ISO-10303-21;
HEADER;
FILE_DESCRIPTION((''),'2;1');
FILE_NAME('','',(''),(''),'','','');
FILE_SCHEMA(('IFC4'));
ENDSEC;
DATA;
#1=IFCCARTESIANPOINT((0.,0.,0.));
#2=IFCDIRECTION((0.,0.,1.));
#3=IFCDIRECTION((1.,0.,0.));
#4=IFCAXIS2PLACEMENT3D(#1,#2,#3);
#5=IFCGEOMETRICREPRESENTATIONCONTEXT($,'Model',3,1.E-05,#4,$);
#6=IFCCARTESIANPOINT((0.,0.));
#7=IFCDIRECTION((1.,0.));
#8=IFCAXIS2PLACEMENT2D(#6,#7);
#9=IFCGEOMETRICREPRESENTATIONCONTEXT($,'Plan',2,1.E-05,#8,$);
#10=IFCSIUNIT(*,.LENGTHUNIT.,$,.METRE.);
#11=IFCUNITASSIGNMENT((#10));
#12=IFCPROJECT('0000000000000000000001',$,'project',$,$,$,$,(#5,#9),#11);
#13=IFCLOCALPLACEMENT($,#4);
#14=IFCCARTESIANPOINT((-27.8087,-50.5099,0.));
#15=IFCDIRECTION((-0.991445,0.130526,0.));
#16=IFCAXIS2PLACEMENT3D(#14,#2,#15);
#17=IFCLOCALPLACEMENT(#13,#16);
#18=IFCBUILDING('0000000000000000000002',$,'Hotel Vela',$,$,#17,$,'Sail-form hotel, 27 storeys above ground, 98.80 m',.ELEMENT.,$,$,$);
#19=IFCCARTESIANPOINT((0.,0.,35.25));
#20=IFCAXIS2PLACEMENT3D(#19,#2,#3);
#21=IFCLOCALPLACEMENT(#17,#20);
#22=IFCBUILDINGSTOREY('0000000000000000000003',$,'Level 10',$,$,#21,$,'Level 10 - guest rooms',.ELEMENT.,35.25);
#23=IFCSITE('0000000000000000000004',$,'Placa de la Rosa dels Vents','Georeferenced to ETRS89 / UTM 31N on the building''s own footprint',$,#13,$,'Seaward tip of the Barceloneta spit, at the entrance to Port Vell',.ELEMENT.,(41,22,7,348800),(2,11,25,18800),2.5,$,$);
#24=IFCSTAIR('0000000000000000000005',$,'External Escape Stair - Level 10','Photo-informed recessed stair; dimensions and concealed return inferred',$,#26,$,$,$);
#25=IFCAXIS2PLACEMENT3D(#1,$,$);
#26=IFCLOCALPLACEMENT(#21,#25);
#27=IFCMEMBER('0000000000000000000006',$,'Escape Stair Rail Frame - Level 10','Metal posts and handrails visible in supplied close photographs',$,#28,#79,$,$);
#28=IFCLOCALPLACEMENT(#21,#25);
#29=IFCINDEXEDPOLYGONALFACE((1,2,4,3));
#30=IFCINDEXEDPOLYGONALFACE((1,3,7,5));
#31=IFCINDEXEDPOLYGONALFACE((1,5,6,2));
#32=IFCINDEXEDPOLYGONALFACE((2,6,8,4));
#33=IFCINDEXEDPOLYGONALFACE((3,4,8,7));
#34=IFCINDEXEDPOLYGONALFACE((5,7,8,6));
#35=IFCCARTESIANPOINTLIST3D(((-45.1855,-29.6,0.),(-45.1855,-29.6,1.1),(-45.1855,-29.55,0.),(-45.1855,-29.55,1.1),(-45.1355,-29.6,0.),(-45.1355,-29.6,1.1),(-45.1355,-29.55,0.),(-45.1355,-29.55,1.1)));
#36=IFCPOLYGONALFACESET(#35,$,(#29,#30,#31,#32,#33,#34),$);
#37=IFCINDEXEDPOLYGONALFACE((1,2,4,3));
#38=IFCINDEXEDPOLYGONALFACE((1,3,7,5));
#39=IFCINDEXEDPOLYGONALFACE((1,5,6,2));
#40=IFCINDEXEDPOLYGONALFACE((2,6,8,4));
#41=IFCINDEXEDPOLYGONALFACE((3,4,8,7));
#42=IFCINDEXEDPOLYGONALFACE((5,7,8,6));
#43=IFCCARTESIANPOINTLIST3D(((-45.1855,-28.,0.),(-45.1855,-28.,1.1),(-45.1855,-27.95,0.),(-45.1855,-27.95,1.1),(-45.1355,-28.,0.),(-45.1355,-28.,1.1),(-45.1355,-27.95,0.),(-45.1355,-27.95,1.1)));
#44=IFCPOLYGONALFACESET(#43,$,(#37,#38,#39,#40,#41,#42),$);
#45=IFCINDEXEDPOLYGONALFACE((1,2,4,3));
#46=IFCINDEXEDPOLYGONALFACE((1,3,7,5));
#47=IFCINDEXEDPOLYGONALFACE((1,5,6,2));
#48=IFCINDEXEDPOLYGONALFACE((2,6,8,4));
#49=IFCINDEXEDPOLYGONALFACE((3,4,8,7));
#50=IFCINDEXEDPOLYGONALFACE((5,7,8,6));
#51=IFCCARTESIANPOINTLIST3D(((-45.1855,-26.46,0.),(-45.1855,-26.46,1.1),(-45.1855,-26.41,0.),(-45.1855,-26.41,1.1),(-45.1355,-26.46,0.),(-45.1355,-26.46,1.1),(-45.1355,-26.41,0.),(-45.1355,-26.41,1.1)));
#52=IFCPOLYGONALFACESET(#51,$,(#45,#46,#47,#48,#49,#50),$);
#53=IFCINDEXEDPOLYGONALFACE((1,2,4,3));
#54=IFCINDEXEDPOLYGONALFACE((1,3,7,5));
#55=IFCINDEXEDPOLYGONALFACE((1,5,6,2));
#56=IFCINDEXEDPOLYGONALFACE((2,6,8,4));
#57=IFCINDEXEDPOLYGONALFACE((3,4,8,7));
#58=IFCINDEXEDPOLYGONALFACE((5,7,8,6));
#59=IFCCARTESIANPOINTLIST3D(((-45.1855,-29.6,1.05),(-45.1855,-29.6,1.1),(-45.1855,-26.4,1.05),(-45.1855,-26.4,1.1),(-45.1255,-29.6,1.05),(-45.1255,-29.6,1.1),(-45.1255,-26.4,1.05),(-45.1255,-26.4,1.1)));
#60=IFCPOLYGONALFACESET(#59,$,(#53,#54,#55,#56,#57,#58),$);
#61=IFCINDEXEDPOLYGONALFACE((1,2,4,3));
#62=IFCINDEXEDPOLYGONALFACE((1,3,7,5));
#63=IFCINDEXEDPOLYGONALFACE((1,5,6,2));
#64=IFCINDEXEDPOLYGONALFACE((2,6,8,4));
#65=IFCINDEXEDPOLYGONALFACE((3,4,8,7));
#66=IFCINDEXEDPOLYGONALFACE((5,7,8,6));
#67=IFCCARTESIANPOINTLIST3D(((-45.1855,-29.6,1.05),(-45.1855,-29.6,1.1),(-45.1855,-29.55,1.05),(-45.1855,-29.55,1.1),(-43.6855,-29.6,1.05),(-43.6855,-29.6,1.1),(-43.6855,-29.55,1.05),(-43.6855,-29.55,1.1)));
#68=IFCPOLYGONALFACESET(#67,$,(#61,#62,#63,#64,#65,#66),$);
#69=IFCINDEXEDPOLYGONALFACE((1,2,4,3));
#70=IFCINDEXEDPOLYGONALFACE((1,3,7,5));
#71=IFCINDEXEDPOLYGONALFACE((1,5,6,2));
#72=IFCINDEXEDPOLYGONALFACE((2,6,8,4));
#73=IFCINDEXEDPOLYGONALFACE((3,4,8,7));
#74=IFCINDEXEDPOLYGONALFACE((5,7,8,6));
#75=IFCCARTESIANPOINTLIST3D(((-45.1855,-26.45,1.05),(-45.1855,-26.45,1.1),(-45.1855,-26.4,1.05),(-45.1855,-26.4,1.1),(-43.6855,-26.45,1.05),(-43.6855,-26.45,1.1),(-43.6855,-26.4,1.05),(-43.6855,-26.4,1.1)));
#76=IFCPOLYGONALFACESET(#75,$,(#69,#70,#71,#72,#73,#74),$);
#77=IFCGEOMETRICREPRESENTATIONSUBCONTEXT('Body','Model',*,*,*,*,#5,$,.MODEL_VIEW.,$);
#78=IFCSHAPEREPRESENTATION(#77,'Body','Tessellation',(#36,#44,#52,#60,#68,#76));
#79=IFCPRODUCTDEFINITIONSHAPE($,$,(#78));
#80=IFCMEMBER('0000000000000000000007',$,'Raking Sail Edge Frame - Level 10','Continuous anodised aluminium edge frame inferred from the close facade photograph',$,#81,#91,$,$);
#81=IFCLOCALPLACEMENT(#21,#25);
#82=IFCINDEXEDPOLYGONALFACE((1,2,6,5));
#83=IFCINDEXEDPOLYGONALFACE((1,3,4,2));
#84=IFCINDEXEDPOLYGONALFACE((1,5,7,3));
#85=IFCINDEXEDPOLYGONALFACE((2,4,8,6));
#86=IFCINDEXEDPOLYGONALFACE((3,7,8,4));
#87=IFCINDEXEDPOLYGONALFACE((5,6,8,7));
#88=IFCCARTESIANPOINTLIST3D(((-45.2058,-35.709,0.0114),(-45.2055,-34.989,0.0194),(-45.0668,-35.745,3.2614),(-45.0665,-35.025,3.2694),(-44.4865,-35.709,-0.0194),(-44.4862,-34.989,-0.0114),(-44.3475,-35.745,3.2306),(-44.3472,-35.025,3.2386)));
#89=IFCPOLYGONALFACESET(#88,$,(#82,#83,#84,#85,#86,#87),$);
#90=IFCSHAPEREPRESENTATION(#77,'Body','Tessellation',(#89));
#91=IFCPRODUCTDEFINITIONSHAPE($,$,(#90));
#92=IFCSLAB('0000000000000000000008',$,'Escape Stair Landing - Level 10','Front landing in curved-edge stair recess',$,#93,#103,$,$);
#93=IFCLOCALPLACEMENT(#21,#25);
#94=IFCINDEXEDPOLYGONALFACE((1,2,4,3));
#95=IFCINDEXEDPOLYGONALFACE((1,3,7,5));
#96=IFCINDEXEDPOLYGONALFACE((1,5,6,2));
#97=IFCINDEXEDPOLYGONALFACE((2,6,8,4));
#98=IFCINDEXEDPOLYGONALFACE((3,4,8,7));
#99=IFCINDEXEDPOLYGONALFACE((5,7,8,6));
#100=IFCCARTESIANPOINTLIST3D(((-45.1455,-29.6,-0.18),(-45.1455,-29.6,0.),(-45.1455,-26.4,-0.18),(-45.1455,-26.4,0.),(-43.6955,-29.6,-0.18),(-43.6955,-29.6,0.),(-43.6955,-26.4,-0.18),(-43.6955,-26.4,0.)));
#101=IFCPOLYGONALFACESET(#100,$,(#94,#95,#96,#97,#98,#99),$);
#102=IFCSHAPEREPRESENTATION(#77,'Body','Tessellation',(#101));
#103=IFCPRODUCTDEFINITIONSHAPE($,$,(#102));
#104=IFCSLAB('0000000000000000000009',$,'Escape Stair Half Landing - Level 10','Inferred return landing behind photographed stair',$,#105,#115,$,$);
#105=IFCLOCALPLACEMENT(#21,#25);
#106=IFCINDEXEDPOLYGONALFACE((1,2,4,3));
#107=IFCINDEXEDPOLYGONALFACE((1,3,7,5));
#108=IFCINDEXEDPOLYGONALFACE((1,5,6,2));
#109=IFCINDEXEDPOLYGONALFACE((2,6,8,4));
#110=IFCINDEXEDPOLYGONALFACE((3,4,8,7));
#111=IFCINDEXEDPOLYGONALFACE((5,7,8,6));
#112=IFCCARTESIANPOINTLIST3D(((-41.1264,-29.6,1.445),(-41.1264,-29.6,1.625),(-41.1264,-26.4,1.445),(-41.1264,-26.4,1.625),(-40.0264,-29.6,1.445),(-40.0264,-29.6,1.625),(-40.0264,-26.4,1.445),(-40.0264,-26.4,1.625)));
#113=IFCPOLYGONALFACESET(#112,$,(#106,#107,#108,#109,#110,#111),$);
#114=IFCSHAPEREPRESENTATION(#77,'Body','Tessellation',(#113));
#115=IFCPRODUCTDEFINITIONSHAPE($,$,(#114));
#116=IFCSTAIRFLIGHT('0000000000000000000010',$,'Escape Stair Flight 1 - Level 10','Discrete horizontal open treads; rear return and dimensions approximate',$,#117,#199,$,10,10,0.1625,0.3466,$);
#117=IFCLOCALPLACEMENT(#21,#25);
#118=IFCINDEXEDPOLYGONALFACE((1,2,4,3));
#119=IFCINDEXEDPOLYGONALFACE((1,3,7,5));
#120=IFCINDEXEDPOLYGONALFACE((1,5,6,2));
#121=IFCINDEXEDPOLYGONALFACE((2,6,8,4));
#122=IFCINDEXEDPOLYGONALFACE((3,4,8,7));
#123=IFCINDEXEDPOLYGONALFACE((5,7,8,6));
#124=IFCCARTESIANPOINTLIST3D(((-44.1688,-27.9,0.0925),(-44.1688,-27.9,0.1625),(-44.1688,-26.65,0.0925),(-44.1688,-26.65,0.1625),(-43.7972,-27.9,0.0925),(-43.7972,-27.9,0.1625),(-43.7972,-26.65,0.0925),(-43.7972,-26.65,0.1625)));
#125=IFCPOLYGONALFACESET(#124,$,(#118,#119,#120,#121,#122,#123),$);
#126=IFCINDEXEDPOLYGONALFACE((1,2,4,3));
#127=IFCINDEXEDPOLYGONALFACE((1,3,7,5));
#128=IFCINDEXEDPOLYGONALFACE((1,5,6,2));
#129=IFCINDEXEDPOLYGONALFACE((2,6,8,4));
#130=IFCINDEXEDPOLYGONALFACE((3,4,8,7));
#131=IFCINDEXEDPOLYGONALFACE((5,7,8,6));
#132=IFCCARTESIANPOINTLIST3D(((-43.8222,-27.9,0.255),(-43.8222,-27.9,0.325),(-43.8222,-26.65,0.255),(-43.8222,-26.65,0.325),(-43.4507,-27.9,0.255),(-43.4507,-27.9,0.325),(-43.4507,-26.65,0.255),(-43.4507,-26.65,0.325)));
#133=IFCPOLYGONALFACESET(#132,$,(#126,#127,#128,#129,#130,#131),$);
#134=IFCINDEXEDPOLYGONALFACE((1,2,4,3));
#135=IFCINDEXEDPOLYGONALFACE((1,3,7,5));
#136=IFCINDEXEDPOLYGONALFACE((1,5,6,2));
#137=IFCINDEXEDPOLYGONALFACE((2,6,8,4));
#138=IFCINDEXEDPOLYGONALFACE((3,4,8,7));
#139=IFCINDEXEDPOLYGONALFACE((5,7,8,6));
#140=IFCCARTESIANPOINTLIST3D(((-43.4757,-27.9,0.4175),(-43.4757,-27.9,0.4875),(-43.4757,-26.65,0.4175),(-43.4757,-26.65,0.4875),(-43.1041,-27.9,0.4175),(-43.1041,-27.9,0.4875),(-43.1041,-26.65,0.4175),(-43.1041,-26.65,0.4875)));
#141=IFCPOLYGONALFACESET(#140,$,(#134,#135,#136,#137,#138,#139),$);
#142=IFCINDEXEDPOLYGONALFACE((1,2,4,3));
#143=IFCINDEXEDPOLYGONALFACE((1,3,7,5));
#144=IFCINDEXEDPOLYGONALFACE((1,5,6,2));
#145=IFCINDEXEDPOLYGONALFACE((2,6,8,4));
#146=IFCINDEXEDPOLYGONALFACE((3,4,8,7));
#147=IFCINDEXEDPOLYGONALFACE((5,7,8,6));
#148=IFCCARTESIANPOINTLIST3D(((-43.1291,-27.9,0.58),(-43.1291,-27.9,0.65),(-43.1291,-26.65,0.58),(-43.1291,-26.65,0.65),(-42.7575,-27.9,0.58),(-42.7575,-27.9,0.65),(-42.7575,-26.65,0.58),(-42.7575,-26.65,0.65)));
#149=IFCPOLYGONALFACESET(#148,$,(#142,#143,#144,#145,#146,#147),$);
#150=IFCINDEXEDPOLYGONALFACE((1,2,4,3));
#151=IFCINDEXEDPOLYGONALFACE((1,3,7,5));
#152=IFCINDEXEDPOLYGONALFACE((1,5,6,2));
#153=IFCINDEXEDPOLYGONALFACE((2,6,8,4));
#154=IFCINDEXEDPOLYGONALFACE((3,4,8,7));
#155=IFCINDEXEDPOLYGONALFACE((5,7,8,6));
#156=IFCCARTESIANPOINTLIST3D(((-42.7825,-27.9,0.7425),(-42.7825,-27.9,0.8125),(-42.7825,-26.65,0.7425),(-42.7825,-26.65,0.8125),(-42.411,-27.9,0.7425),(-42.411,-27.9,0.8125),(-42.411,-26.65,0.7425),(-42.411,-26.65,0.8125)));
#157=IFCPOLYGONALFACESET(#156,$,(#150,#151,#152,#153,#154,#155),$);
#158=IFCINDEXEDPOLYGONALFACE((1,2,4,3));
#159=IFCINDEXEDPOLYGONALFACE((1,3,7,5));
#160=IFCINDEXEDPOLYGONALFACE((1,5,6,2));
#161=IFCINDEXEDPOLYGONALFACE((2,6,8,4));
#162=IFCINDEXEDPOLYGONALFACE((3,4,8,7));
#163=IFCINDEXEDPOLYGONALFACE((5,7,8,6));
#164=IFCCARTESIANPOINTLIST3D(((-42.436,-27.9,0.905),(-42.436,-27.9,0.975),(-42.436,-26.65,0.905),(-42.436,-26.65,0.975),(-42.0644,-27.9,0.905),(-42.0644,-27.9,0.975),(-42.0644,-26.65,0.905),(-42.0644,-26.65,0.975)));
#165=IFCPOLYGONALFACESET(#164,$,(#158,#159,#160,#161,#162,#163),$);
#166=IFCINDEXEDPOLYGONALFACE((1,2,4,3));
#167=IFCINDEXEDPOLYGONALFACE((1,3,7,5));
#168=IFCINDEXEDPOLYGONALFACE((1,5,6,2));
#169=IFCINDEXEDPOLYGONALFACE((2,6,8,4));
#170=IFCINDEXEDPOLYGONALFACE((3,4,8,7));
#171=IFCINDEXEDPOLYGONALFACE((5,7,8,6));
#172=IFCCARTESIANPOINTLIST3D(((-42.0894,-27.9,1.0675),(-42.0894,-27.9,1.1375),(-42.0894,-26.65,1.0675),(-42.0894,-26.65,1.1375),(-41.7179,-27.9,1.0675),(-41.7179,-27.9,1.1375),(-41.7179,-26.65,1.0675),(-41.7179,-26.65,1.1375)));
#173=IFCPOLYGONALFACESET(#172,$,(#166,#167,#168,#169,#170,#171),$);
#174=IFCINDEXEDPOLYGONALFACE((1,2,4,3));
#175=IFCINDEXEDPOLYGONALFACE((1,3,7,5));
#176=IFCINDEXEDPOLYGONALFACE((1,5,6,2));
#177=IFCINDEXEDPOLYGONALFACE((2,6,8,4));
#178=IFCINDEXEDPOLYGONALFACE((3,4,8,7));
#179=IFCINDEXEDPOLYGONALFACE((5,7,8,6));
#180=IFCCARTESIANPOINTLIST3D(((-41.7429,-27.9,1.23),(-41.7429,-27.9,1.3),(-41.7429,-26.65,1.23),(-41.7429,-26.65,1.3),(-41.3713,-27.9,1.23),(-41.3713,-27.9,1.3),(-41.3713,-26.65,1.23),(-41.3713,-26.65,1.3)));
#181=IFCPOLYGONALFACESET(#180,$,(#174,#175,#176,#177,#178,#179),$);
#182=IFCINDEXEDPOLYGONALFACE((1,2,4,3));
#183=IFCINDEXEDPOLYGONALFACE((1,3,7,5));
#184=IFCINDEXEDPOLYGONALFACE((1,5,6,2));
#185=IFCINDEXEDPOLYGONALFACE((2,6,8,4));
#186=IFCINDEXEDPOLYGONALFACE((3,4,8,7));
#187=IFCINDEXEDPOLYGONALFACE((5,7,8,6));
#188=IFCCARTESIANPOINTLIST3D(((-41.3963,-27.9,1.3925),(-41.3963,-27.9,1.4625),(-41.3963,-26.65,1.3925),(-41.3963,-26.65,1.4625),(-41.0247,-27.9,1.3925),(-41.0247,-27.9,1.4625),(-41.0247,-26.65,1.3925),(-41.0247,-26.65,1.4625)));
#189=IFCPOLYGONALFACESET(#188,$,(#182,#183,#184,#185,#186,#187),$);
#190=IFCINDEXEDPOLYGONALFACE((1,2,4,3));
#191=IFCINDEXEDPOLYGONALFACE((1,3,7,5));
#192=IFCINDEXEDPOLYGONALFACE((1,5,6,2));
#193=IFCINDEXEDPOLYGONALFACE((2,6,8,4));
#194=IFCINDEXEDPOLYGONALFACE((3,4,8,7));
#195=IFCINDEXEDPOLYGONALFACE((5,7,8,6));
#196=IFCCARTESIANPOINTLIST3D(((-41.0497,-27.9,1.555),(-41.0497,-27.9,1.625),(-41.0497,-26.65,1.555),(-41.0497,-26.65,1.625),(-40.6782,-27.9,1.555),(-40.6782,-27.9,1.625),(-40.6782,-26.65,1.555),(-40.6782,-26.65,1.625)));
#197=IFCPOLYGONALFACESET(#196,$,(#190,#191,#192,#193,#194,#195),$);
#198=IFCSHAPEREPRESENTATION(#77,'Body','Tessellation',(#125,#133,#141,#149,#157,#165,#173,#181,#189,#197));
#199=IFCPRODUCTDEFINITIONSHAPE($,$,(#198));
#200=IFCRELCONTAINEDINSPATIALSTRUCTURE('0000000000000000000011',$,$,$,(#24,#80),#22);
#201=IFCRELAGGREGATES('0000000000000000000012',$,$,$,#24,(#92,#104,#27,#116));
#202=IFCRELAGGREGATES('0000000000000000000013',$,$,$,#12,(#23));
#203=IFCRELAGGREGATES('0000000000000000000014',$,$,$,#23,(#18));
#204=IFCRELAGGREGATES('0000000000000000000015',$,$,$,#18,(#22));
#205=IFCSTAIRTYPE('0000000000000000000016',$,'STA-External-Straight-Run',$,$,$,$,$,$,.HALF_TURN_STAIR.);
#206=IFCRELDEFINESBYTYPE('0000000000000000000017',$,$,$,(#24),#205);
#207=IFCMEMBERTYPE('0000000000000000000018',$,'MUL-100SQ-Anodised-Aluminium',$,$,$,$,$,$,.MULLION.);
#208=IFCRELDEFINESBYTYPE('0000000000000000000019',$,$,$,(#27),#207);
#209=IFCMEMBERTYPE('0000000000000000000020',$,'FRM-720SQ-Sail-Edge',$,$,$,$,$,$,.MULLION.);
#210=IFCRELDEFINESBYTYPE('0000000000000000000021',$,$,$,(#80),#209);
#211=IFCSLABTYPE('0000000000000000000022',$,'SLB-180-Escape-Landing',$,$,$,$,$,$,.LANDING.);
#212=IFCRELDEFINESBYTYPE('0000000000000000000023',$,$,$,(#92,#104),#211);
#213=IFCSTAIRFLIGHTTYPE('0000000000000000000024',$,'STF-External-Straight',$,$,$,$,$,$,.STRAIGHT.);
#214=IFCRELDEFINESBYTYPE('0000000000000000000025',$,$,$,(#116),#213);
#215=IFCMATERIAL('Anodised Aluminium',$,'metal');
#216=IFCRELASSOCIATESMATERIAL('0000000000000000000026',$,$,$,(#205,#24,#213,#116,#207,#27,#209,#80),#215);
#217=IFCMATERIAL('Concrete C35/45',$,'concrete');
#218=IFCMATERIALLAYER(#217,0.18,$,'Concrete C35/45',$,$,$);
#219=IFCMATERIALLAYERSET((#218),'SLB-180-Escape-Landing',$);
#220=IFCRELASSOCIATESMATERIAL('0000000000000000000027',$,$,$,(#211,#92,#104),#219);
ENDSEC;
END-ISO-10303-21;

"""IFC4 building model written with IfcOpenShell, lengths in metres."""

from ifc_helpers import new_model, si_unit, frame, origin_with_axes, origin_2d_with_axis, place, context, subcontext, project, spatial, line, indexed_curve, rectangle, outline, extrude, material, layer, layer_set, layer_usage, material_profile, profile_set, profile_usage, type_object, element, aggregate, save


model = new_model("IFC4")

# Units and contexts
model_context = context("Model", 3, precision=1e-05, world=origin_with_axes())
plan_context = context("Plan", 2, precision=1e-05, world=origin_2d_with_axis())
body_context = subcontext(model_context, "Body", "Model", "MODEL_VIEW")
ifc_project = project(units=[si_unit("LENGTHUNIT", "METRE")], contexts=[model_context, plan_context])

# Site, building, storey
site_placement = place(None, origin_with_axes())
site = spatial("IfcSite", under=ifc_project, at=site_placement, Name="Placa de la Rosa dels Vents", Description="Georeferenced to ETRS89 / UTM 31N on the building's own footprint", LongName="Seaward tip of the Barceloneta spit, at the entrance to Port Vell", CompositionType="ELEMENT", RefLatitude=(41, 22, 7, 348800), RefLongitude=(2, 11, 25, 18800), RefElevation=2.5)
building_placement = place(site_placement, frame((-27.8087, -50.5099, 0.0), z_axis=(0.0, 0.0, 1.0), x_axis=(-0.991445, 0.130526, 0.0)))
building = spatial("IfcBuilding", under=site, at=building_placement, Name="Hotel Vela", LongName="Sail-form hotel, 27 storeys above ground, 98.80 m", CompositionType="ELEMENT")
storey_placement = place(building_placement, frame((0.0, 0.0, 35.25), z_axis=(0.0, 0.0, 1.0), x_axis=(1.0, 0.0, 0.0)))
storey = spatial("IfcBuildingStorey", under=building, at=storey_placement, Name="Level 10", LongName="Level 10 - guest rooms", CompositionType="ELEMENT", Elevation=35.25)

# Stair, member
ifc_material_1 = material(Name="Anodised Aluminium", Category="metal")
stair_type = type_object("IfcStairType", Name="STA-External-Straight-Run", PredefinedType="HALF_TURN_STAIR", material=ifc_material_1)
stair_placement = place(storey_placement, frame((0.0, 0.0, -35.25), z_axis=(0.0, 0.0, 1.0), x_axis=(1.0, 0.0, 0.0)))
stair = element("IfcStair", 1, at=stair_placement, inside=storey, type_object=stair_type, material=ifc_material_1, Name="External Escape Stair - Level 10", Description="Photo-informed recessed stair; dimensions and concealed return inferred")
ifc_material_profile_1 = material_profile(ifc_material_1, rectangle(XDim=0.1, YDim=0.1))
ifc_profile_set_1 = profile_set([ifc_material_profile_1], Name="MUL-100SQ-Anodised-Aluminium")
ifc_profile_usage_1 = profile_usage(ifc_profile_set_1)
member_type_1 = type_object("IfcMemberType", Name="MUL-100SQ-Anodised-Aluminium", PredefinedType="MULLION", material=ifc_profile_set_1)
member_1_placement = place(stair_placement, origin_with_axes())
member_1 = element("IfcMember", 2, at=member_1_placement, type_object=member_type_1, material=ifc_profile_usage_1, Name="Escape Stair Rail Frame - Level 10", Description="Metal posts and handrails visible in supplied close photographs", context=body_context, shape_type="SweptSolid", body=[
    extrude(outline(indexed_curve([(0.0, 0.0), (0.05, 0.0), (0.05, 0.05), (0.0, 0.05)], segments=[line(1, 2, 3, 4, 1)])), frame((-45.1855, -29.6, 35.25), z_axis=(0.0, 0.0, 1.0), x_axis=(1.0, 0.0, 0.0)), (0.0, 0.0, 1.0), 1.1),
    extrude(outline(indexed_curve([(0.0, 0.0), (0.05, 0.0), (0.05, 0.05), (0.0, 0.05)], segments=[line(1, 2, 3, 4, 1)])), frame((-45.1855, -28.0, 35.25), z_axis=(0.0, 0.0, 1.0), x_axis=(1.0, 0.0, 0.0)), (0.0, 0.0, 1.0), 1.1),
    extrude(outline(indexed_curve([(0.0, 0.0), (0.05, 0.0), (0.05, 0.05), (0.0, 0.05)], segments=[line(1, 2, 3, 4, 1)])), frame((-45.1855, -26.46, 35.25), z_axis=(0.0, 0.0, 1.0), x_axis=(1.0, 0.0, 0.0)), (0.0, 0.0, 1.0), 1.1),
    extrude(outline(indexed_curve([(0.0, 0.0), (0.06, 0.0), (0.06, 3.2), (0.0, 3.2)], segments=[line(1, 2, 3, 4, 1)])), frame((-45.1855, -29.6, 36.3), z_axis=(0.0, 0.0, 1.0), x_axis=(1.0, 0.0, 0.0)), (0.0, 0.0, 1.0), 0.05),
    extrude(outline(indexed_curve([(0.0, 0.0), (1.5, 0.0), (1.5, 0.05), (0.0, 0.05)], segments=[line(1, 2, 3, 4, 1)])), frame((-45.1855, -29.6, 36.3), z_axis=(0.0, 0.0, 1.0), x_axis=(1.0, 0.0, 0.0)), (0.0, 0.0, 1.0), 0.05),
    extrude(outline(indexed_curve([(0.0, 0.0), (1.5, 0.0), (1.5, 0.05), (0.0, 0.05)], segments=[line(1, 2, 3, 4, 1)])), frame((-45.1855, -26.45, 36.3), z_axis=(0.0, 0.0, 1.0), x_axis=(1.0, 0.0, 0.0)), (0.0, 0.0, 1.0), 0.05),
])

# Member
ifc_material_profile_2 = material_profile(ifc_material_1, rectangle(XDim=0.72, YDim=0.72))
ifc_profile_set_2 = profile_set([ifc_material_profile_2], Name="FRM-720SQ-Sail-Edge")
ifc_profile_usage_2 = profile_usage(ifc_profile_set_2)
member_type_2 = type_object("IfcMemberType", Name="FRM-720SQ-Sail-Edge", PredefinedType="MULLION", material=ifc_profile_set_2)
member_2_placement = place(storey_placement, frame((-44.846, -35.349, 0.0), z_axis=(0.042728, -0.011066, 0.999025), x_axis=(0.999087, 0.0, -0.04273)))
element("IfcMember", 3, at=member_2_placement, inside=storey, type_object=member_type_2, material=ifc_profile_usage_2, Name="Raking Sail Edge Frame - Level 10", Description="Continuous anodised aluminium edge frame inferred from the close facade photograph", context=body_context, shape_type="SweptSolid", body=[
    extrude(outline(indexed_curve([(-0.36, -0.36), (0.36, -0.36), (0.36, 0.36), (-0.36, 0.36)], segments=[line(1, 2, 3, 4, 1)])), origin_with_axes(), (0.0, 0.0, 1.0), 3.2532),
])

# Slabs
ifc_material_2 = material(Name="Concrete C35/45", Category="concrete")
ifc_layer = layer(ifc_material_2, 0.18, Name="Concrete C35/45")
ifc_layer_set = layer_set([ifc_layer], Name="SLB-180-Escape-Landing")
ifc_layer_usage_1 = layer_usage(ifc_layer_set, "AXIS3", "POSITIVE", 0.0)
slab_type = type_object("IfcSlabType", Name="SLB-180-Escape-Landing", PredefinedType="LANDING", material=ifc_layer_set)
slab_1_placement = place(stair_placement, frame((-45.1455, -29.6, 35.07), z_axis=(0.0, 0.0, 1.0), x_axis=(1.0, 0.0, 0.0)))
slab_1 = element("IfcSlab", 4, at=slab_1_placement, type_object=slab_type, material=ifc_layer_usage_1, Name="Escape Stair Landing - Level 10", Description="Front landing in curved-edge stair recess", context=body_context, shape_type="SweptSolid", body=[
    extrude(outline(indexed_curve([(0.0, 0.0), (1.45, 0.0), (1.45, 3.2), (0.0, 3.2)], segments=[line(1, 2, 3, 4, 1)])), origin_with_axes(), (0.0, 0.0, 1.0), 0.18),
])
ifc_layer_usage_2 = layer_usage(ifc_layer_set, "AXIS3", "POSITIVE", 0.0)
slab_2_placement = place(stair_placement, frame((-41.1264, -29.6, 36.695), z_axis=(0.0, 0.0, 1.0), x_axis=(1.0, 0.0, 0.0)))
slab_2 = element("IfcSlab", 5, at=slab_2_placement, type_object=slab_type, material=ifc_layer_usage_2, Name="Escape Stair Half Landing - Level 10", Description="Inferred return landing behind photographed stair", context=body_context, shape_type="SweptSolid", body=[
    extrude(outline(indexed_curve([(0.0, 0.0), (1.1, 0.0), (1.1, 3.2), (0.0, 3.2)], segments=[line(1, 2, 3, 4, 1)])), origin_with_axes(), (0.0, 0.0, 1.0), 0.18),
])

# Stair flight
stair_flight_type = type_object("IfcStairFlightType", Name="STF-External-Straight", PredefinedType="STRAIGHT", material=ifc_material_1)
stair_flight_1_placement = place(stair_placement, origin_with_axes())
stair_flight_1 = element("IfcStairFlight", 6, at=stair_flight_1_placement, type_object=stair_flight_type, material=ifc_material_1, Name="Escape Stair Flight 1 - Level 10", Description="Discrete horizontal open treads; rear return and dimensions approximate", NumberOfRisers=10, NumberOfTreads=10, RiserHeight=0.1625, TreadLength=0.3466, context=body_context, shape_type="SweptSolid", body=[
    extrude(outline(indexed_curve([(0.0, 0.0), (0.3716, 0.0), (0.3716, 1.25), (0.0, 1.25)], segments=[line(1, 2, 3, 4, 1)])), frame((-44.1688, -27.9, 35.3425), z_axis=(0.0, 0.0, 1.0), x_axis=(1.0, 0.0, 0.0)), (0.0, 0.0, 1.0), 0.07),
    extrude(outline(indexed_curve([(0.0, 0.0), (0.3716, 0.0), (0.3716, 1.25), (0.0, 1.25)], segments=[line(1, 2, 3, 4, 1)])), frame((-43.8222, -27.9, 35.505), z_axis=(0.0, 0.0, 1.0), x_axis=(1.0, 0.0, 0.0)), (0.0, 0.0, 1.0), 0.07),
    extrude(outline(indexed_curve([(0.0, 0.0), (0.3716, 0.0), (0.3716, 1.25), (0.0, 1.25)], segments=[line(1, 2, 3, 4, 1)])), frame((-43.4757, -27.9, 35.6675), z_axis=(0.0, 0.0, 1.0), x_axis=(1.0, 0.0, 0.0)), (0.0, 0.0, 1.0), 0.07),
    extrude(outline(indexed_curve([(0.0, 0.0), (0.3716, 0.0), (0.3716, 1.25), (0.0, 1.25)], segments=[line(1, 2, 3, 4, 1)])), frame((-43.1291, -27.9, 35.83), z_axis=(0.0, 0.0, 1.0), x_axis=(1.0, 0.0, 0.0)), (0.0, 0.0, 1.0), 0.07),
    extrude(outline(indexed_curve([(0.0, 0.0), (0.3716, 0.0), (0.3716, 1.25), (0.0, 1.25)], segments=[line(1, 2, 3, 4, 1)])), frame((-42.7825, -27.9, 35.9925), z_axis=(0.0, 0.0, 1.0), x_axis=(1.0, 0.0, 0.0)), (0.0, 0.0, 1.0), 0.07),
    extrude(outline(indexed_curve([(0.0, 0.0), (0.3716, 0.0), (0.3716, 1.25), (0.0, 1.25)], segments=[line(1, 2, 3, 4, 1)])), frame((-42.436, -27.9, 36.155), z_axis=(0.0, 0.0, 1.0), x_axis=(1.0, 0.0, 0.0)), (0.0, 0.0, 1.0), 0.07),
    extrude(outline(indexed_curve([(0.0, 0.0), (0.3716, 0.0), (0.3716, 1.25), (0.0, 1.25)], segments=[line(1, 2, 3, 4, 1)])), frame((-42.0894, -27.9, 36.3175), z_axis=(0.0, 0.0, 1.0), x_axis=(1.0, 0.0, 0.0)), (0.0, 0.0, 1.0), 0.07),
    extrude(outline(indexed_curve([(0.0, 0.0), (0.3716, 0.0), (0.3716, 1.25), (0.0, 1.25)], segments=[line(1, 2, 3, 4, 1)])), frame((-41.7429, -27.9, 36.48), z_axis=(0.0, 0.0, 1.0), x_axis=(1.0, 0.0, 0.0)), (0.0, 0.0, 1.0), 0.07),
    extrude(outline(indexed_curve([(0.0, 0.0), (0.3716, 0.0), (0.3716, 1.25), (0.0, 1.25)], segments=[line(1, 2, 3, 4, 1)])), frame((-41.3963, -27.9, 36.6425), z_axis=(0.0, 0.0, 1.0), x_axis=(1.0, 0.0, 0.0)), (0.0, 0.0, 1.0), 0.07),
    extrude(outline(indexed_curve([(0.0, 0.0), (0.3716, 0.0), (0.3716, 1.25), (0.0, 1.25)], segments=[line(1, 2, 3, 4, 1)])), frame((-41.0497, -27.9, 36.805), z_axis=(0.0, 0.0, 1.0), x_axis=(1.0, 0.0, 0.0)), (0.0, 0.0, 1.0), 0.07),
])

aggregate(stair, [slab_1, slab_2, member_1, stair_flight_1])

save(model, "model.ifc")
